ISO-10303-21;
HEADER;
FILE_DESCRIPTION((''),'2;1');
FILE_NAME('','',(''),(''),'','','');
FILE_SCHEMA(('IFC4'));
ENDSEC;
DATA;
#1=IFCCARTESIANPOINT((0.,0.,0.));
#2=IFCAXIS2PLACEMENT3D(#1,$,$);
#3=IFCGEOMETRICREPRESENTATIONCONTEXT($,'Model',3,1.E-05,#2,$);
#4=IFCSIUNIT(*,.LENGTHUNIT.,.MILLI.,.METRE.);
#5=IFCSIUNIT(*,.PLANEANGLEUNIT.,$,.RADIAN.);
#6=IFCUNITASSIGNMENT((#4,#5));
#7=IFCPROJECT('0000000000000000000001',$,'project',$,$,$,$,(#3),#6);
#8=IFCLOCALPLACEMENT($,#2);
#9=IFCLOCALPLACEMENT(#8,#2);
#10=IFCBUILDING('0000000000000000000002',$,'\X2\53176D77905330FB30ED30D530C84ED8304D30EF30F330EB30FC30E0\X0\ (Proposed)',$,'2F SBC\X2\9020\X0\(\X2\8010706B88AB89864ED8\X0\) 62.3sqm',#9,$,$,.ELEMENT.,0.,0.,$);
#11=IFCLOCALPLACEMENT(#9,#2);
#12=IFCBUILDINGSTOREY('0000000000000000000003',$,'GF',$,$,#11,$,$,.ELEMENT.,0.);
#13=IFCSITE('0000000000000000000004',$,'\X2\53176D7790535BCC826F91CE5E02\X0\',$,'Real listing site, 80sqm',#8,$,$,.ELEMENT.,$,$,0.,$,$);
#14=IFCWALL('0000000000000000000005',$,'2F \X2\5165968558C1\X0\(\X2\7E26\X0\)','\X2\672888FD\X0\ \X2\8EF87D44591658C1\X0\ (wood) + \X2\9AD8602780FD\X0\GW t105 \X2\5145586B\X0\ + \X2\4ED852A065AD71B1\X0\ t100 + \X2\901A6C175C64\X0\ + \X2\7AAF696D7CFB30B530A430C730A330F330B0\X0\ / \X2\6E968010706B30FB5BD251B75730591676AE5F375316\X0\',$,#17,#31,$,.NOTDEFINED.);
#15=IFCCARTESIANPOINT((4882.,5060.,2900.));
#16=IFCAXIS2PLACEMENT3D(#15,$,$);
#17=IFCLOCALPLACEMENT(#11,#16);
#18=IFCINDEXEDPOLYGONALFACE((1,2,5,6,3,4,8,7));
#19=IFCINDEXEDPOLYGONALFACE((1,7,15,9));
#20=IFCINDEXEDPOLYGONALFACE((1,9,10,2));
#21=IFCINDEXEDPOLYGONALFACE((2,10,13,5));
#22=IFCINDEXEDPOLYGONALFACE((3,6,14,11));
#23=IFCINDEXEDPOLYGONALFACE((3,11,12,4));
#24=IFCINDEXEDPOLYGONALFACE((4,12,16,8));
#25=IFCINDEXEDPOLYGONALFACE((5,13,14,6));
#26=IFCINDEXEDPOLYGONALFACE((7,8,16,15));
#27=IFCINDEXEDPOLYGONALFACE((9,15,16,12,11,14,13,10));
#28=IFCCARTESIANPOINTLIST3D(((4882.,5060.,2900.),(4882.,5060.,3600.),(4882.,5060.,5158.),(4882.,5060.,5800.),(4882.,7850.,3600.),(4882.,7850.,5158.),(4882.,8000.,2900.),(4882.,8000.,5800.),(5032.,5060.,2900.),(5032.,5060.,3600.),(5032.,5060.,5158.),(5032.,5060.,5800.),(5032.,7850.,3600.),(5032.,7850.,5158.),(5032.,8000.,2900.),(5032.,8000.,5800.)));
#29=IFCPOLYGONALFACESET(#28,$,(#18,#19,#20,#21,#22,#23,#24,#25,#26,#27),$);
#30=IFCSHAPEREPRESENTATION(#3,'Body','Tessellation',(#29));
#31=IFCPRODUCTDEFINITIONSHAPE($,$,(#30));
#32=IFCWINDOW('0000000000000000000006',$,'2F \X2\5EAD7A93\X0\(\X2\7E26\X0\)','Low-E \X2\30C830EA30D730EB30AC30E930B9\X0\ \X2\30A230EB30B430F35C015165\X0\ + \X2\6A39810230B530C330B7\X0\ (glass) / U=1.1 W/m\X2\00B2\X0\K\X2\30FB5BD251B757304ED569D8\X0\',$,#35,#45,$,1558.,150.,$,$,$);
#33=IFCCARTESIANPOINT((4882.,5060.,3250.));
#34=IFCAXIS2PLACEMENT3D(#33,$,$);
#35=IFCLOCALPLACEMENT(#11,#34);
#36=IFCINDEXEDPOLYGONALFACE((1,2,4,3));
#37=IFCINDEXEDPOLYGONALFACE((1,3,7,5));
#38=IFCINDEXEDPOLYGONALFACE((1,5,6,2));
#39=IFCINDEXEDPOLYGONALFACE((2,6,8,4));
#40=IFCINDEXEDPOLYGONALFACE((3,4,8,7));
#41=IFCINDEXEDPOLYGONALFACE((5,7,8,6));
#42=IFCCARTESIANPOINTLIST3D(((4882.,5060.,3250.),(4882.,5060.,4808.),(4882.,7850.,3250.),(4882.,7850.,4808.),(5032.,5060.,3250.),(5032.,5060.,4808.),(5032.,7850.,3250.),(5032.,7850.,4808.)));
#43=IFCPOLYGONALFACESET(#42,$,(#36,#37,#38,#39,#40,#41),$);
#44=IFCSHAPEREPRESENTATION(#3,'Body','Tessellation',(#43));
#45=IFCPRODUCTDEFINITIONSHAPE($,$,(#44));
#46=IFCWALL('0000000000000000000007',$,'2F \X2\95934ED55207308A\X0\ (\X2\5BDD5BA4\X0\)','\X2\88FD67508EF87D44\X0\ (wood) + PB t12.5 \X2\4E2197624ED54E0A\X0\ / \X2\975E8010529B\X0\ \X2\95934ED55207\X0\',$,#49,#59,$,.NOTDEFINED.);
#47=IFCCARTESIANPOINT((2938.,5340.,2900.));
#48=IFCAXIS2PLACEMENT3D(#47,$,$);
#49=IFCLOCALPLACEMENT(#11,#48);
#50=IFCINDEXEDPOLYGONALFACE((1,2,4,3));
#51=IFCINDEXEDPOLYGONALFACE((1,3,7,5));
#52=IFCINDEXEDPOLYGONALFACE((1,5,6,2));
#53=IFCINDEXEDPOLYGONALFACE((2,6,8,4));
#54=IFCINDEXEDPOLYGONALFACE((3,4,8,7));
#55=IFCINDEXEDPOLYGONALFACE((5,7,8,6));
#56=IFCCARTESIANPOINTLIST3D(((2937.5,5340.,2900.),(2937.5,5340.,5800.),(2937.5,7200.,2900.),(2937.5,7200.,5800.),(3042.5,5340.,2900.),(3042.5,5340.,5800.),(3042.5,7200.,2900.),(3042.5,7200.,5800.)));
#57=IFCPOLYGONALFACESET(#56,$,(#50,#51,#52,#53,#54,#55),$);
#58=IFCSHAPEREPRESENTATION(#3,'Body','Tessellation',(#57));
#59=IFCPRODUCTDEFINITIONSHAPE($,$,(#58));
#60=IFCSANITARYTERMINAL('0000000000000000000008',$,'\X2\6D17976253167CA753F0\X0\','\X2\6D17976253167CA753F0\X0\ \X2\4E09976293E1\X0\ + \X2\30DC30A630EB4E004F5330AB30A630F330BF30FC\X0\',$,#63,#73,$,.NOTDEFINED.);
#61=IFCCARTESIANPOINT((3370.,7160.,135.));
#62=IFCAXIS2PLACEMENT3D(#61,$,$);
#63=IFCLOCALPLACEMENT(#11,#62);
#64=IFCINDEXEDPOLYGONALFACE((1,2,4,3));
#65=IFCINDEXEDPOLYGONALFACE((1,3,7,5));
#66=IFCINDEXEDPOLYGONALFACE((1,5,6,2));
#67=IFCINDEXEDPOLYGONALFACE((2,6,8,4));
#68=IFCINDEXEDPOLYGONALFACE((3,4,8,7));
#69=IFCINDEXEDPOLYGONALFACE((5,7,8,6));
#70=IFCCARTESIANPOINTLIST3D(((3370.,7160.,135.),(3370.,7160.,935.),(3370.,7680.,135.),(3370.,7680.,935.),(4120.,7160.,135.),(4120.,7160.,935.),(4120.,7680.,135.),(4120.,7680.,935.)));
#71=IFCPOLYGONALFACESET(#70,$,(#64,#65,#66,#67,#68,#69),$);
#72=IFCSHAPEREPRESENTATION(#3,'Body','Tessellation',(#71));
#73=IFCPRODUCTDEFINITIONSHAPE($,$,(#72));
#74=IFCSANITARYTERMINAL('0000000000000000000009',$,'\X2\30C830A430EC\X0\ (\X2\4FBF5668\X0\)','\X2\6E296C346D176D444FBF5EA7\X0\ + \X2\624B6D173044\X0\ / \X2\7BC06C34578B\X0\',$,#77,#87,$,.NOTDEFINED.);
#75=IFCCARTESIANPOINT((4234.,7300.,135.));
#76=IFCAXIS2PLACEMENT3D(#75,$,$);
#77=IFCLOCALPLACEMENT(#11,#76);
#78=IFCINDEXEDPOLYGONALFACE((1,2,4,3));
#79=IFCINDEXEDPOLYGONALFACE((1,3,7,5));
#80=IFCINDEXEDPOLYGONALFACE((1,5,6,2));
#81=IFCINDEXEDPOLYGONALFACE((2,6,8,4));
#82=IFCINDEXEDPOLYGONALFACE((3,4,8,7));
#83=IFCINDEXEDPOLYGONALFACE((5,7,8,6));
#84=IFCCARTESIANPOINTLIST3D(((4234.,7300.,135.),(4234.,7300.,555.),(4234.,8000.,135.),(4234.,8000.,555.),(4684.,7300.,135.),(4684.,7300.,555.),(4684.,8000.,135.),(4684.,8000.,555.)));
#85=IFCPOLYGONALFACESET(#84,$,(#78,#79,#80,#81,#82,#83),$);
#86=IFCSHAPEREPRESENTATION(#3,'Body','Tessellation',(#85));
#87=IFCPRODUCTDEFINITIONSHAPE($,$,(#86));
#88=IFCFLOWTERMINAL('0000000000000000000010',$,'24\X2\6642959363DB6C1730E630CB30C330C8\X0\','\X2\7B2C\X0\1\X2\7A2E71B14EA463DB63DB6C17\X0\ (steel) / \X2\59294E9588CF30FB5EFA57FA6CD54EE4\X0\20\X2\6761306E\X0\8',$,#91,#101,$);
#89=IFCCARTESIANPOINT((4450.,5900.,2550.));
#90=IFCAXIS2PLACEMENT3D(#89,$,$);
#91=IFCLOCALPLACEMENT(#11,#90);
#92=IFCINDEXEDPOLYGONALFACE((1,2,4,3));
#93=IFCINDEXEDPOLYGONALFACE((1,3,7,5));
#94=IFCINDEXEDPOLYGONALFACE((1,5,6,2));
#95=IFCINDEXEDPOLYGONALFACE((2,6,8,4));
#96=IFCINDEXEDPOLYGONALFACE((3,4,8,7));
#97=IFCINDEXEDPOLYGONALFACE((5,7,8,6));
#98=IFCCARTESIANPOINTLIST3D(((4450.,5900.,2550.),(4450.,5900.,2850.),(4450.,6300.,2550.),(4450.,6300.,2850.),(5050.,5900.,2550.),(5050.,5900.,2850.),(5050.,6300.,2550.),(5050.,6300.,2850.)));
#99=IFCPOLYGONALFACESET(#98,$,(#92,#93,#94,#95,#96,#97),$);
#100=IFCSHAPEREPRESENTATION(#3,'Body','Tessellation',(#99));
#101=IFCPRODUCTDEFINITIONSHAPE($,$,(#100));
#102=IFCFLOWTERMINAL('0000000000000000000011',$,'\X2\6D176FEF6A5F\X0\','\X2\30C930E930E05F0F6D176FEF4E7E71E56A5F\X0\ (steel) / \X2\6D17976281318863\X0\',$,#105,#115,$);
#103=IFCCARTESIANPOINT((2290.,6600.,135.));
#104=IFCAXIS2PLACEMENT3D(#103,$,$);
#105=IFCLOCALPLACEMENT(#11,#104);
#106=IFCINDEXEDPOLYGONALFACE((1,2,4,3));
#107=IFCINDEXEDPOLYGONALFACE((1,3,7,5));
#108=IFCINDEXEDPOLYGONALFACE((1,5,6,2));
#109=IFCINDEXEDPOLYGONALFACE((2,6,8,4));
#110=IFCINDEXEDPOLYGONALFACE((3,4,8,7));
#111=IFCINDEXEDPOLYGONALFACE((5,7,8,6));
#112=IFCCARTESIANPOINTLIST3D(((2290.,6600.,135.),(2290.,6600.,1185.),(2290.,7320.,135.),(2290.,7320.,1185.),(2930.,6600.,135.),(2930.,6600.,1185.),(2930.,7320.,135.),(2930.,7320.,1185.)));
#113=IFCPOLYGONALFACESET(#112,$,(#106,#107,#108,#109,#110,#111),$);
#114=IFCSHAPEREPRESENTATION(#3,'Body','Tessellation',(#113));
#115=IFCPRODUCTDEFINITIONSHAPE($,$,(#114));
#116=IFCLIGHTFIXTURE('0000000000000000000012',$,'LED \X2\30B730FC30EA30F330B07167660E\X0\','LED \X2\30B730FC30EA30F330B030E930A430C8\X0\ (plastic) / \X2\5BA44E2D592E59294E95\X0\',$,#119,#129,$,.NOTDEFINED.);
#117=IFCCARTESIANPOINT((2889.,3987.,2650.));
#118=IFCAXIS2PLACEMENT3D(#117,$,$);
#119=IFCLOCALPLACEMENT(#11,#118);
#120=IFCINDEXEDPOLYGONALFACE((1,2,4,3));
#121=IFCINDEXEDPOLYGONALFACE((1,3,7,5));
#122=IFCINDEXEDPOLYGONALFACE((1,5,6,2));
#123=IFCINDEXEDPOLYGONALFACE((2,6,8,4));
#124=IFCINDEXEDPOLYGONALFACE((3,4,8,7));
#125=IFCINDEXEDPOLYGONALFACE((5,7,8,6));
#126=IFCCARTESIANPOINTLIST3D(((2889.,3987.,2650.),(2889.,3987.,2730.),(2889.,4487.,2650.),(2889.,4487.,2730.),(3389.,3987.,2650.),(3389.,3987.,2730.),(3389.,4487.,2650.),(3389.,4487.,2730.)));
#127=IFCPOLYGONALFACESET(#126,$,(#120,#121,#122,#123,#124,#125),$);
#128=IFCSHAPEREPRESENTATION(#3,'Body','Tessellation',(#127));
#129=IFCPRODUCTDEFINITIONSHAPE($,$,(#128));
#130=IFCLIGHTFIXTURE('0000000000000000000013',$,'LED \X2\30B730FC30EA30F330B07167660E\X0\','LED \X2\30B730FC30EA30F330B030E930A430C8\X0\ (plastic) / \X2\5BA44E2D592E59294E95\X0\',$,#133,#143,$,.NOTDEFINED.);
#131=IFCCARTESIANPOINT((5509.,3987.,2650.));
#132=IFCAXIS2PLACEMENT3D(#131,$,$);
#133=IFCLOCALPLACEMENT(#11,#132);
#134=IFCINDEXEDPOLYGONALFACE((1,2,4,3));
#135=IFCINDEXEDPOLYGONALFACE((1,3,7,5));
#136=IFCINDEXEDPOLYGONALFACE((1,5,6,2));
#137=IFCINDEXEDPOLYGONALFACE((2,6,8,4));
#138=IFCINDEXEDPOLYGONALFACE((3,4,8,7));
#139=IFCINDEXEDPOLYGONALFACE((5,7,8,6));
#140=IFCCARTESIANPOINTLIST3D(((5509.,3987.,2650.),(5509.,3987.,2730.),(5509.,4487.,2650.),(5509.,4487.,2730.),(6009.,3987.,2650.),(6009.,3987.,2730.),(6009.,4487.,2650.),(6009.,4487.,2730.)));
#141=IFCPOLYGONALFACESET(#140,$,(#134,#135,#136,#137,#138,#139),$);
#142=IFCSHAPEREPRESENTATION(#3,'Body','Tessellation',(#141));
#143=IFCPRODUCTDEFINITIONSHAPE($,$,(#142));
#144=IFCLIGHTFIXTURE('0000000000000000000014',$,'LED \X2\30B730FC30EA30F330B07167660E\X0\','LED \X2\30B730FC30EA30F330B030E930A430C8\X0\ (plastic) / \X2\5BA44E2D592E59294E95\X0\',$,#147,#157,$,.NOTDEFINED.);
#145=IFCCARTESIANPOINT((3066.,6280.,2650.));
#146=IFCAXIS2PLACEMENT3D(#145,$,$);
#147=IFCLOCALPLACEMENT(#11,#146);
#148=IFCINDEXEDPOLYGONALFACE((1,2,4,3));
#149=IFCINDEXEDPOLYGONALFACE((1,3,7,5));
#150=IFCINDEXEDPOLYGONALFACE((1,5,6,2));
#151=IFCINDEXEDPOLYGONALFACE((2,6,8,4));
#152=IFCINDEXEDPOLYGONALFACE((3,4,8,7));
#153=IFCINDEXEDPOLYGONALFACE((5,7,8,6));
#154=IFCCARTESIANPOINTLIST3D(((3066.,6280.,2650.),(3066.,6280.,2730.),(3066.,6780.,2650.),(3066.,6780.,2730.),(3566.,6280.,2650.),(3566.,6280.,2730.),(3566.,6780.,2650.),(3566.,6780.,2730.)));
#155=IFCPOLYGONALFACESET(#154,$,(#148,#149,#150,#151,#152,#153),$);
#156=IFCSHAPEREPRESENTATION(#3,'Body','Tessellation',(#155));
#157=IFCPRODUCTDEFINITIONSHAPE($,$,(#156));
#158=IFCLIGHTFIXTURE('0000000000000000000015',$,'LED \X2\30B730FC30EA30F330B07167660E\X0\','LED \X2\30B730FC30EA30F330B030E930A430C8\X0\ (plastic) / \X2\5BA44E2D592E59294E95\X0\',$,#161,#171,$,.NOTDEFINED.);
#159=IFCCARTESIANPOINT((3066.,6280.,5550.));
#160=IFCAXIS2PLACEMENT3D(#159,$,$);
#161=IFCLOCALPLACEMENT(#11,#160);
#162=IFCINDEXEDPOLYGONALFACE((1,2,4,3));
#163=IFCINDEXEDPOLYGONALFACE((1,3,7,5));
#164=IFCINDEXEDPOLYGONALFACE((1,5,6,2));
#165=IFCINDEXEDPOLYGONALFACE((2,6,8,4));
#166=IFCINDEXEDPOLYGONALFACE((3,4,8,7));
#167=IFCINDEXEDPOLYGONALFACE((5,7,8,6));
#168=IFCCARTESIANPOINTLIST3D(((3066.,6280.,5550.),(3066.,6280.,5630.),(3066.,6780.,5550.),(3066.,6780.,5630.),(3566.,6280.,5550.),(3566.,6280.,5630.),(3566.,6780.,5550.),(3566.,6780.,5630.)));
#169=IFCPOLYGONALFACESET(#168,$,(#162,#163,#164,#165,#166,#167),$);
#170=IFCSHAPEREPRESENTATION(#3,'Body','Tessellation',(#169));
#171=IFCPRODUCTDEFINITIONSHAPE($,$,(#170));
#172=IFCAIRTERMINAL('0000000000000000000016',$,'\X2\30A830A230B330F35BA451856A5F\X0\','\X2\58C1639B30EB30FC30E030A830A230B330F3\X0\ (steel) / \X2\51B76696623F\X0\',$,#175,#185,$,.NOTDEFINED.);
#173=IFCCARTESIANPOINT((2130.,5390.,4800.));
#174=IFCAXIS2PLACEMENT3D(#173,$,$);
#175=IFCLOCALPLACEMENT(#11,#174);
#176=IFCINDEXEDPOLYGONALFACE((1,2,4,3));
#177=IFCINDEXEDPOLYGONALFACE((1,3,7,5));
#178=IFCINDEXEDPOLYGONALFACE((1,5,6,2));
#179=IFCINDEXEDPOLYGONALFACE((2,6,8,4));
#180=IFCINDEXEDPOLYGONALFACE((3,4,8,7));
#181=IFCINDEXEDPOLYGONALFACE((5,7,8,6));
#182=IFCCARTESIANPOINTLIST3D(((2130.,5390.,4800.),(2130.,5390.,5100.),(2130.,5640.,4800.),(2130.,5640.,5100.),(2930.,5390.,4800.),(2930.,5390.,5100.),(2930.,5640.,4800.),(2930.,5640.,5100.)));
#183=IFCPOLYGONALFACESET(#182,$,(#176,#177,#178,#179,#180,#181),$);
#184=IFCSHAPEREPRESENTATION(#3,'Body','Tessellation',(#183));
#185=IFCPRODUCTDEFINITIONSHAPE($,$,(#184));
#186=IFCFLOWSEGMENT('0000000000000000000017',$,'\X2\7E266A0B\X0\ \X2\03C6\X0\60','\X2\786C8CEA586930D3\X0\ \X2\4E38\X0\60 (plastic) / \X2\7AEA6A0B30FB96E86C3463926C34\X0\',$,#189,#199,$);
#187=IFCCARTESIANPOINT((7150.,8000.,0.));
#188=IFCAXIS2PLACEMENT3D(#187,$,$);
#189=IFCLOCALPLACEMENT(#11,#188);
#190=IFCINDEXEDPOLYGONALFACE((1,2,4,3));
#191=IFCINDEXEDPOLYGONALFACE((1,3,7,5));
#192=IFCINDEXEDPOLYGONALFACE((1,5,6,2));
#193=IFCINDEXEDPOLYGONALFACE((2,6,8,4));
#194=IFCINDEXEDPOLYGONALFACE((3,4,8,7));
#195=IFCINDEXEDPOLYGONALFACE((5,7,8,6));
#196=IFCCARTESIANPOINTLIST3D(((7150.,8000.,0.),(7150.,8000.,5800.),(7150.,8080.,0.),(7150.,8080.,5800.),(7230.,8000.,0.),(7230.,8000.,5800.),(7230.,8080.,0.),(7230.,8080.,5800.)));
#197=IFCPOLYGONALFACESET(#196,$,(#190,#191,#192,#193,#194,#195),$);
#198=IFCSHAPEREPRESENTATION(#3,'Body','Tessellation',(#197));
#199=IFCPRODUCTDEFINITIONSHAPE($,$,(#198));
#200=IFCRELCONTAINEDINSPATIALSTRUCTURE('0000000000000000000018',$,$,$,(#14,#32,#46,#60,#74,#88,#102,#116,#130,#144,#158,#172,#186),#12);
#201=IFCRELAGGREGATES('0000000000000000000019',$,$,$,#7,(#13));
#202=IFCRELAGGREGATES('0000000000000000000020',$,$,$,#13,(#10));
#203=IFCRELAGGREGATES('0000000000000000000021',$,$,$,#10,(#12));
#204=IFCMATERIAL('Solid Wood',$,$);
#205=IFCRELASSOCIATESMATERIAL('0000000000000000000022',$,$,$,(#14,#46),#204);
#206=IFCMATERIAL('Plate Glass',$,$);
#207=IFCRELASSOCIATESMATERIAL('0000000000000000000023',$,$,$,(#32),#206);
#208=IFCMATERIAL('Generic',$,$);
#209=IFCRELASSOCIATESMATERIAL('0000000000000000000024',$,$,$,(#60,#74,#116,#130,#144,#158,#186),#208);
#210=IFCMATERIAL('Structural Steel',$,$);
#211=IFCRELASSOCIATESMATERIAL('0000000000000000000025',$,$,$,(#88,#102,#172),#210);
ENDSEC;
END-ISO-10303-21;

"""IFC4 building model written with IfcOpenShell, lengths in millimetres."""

from ifc_helpers import new_model, si_unit, frame, frame_2d, origin, place, context, project, spatial, rectangle, extrude, material, element, fill, save


model = new_model("IFC4")

# Units and contexts
model_context = context("Model", 3, precision=1e-05, world=origin())
ifc_project = project(units=[si_unit("LENGTHUNIT", "METRE", prefix="MILLI"), si_unit("PLANEANGLEUNIT", "RADIAN")], contexts=[model_context])

# Site, building, storey
site_placement = place(None, origin())
site = spatial("IfcSite", under=ifc_project, at=site_placement, Name="北海道富良野市", ObjectType="Real listing site, 80sqm", CompositionType="ELEMENT", RefElevation=0.0)
building_placement = place(site_placement, origin())
building = spatial("IfcBuilding", under=site, at=building_placement, Name="北海道・ロフト付きワンルーム (Proposed)", ObjectType="2F SBC造(耐火被覆付) 62.3sqm", CompositionType="ELEMENT", ElevationOfRefHeight=0.0, ElevationOfTerrain=0.0)
storey_placement = place(building_placement, origin())
storey = spatial("IfcBuildingStorey", under=building, at=storey_placement, Name="GF", CompositionType="ELEMENT", Elevation=0.0)

# Shared definitions
ifc_material_1 = material(Name="Solid Wood")

# Shared definitions
ifc_material_2 = material(Name="Plate Glass")

# Wall, opening, window
wall_1_placement = place(storey_placement, frame((4882.0, 5060.0, 2900.0)))
wall_1 = element("IfcWall", 1, at=wall_1_placement, inside=storey, material=ifc_material_1, Name="2F 入隅壁(縦)", Description="木製 軸組外壁 (wood) + 高性能GW t105 充填 + 付加断熱 t100 + 通気層 + 窯業系サイディング / 準耐火・寒冷地外皮強化", PredefinedType="NOTDEFINED", context=model_context, shape_type="SweptSolid", body=[
    extrude(rectangle(XDim=150.0, YDim=2940.0, at=frame_2d((75.0, 1470.0))), frame((4882.0, 5060.0, 2900.0)), (0.0, 0.0, 1.0), 2900.0),
])
opening_1_placement = place(storey_placement, frame((4882.0, 5060.0, 3250.0)))
opening_1 = element("IfcOpeningElement", 2, at=opening_1_placement, cuts=wall_1, PredefinedType="NOTDEFINED", context=model_context, shape_type="SweptSolid", body=[
    extrude(rectangle(XDim=150.0, YDim=2790.0, at=frame_2d((75.0, 1395.0))), frame((4882.0, 5060.0, 3250.0)), (0.0, 0.0, 1.0), 1558.0),
])
window_1_placement = place(storey_placement, frame((4882.0, 5060.0, 3250.0)))
window_1 = element("IfcWindow", 3, at=window_1_placement, inside=storey, material=ifc_material_2, Name="2F 庭窓(縦)", Description="Low-E トリプルガラス アルゴン封入 + 樹脂サッシ (glass) / U=1.1 W/m²K・寒冷地仕様", OverallHeight=1558.0, OverallWidth=150.0, context=model_context, shape_type="SweptSolid", body=[
    extrude(rectangle(XDim=150.0, YDim=2790.0, at=frame_2d((75.0, 1395.0))), frame((4882.0, 5060.0, 3250.0)), (0.0, 0.0, 1.0), 1558.0),
])
fill(opening_1, window_1)

# Wall
wall_2_placement = place(storey_placement, frame((2938.0, 5340.0, 2900.0)))
element("IfcWall", 4, at=wall_2_placement, inside=storey, material=ifc_material_1, Name="2F 間仕切り (寝室)", Description="製材軸組 (wood) + PB t12.5 両面仕上 / 非耐力 間仕切", PredefinedType="NOTDEFINED", context=model_context, shape_type="SweptSolid", body=[
    extrude(rectangle(XDim=105.0, YDim=1860.0, at=frame_2d((52.0, 930.0))), frame((2938.0, 5340.0, 2900.0)), (0.0, 0.0, 1.0), 2900.0),
])

# Sanitary terminals
ifc_material_3 = material(Name="Generic")
sanitary_terminal_1_placement = place(storey_placement, frame((3370.0, 7160.0, 135.0)))
element("IfcSanitaryTerminal", 5, at=sanitary_terminal_1_placement, inside=storey, material=ifc_material_3, Name="洗面化粧台", Description="洗面化粧台 三面鏡 + ボウル一体カウンター", PredefinedType="NOTDEFINED", context=model_context, shape_type="SweptSolid", body=[
    extrude(rectangle(XDim=750.0, YDim=520.0, at=frame_2d((375.0, 260.0))), frame((3370.0, 7160.0, 135.0)), (0.0, 0.0, 1.0), 800.0),
])
sanitary_terminal_2_placement = place(storey_placement, frame((4234.0, 7300.0, 135.0)))
element("IfcSanitaryTerminal", 6, at=sanitary_terminal_2_placement, inside=storey, material=ifc_material_3, Name="トイレ (便器)", Description="温水洗浄便座 + 手洗い / 節水型", PredefinedType="NOTDEFINED", context=model_context, shape_type="SweptSolid", body=[
    extrude(rectangle(XDim=450.0, YDim=700.0, at=frame_2d((225.0, 350.0))), frame((4234.0, 7300.0, 135.0)), (0.0, 0.0, 1.0), 420.0),
])

# Flow terminals
ifc_material_4 = material(Name="Structural Steel")
flow_terminal_1_placement = place(storey_placement, frame((4450.0, 5900.0, 2550.0)))
element("IfcFlowTerminal", 7, at=flow_terminal_1_placement, inside=storey, material=ifc_material_4, Name="24時間換気ユニット", Description="第1種熱交換換気 (steel) / 天井裏・建基法令20条の8", context=model_context, shape_type="SweptSolid", body=[
    extrude(rectangle(XDim=600.0, YDim=400.0, at=frame_2d((300.0, 200.0))), frame((4450.0, 5900.0, 2550.0)), (0.0, 0.0, 1.0), 300.0),
])
flow_terminal_2_placement = place(storey_placement, frame((2290.0, 6600.0, 135.0)))
element("IfcFlowTerminal", 8, at=flow_terminal_2_placement, inside=storey, material=ifc_material_4, Name="洗濯機", Description="ドラム式洗濯乾燥機 (steel) / 洗面脱衣", context=model_context, shape_type="SweptSolid", body=[
    extrude(rectangle(XDim=640.0, YDim=720.0, at=frame_2d((320.0, 360.0))), frame((2290.0, 6600.0, 135.0)), (0.0, 0.0, 1.0), 1050.0),
])

# Light fixtures
light_fixture_1_placement = place(storey_placement, frame((2889.0, 3987.0, 2650.0)))
element("IfcLightFixture", 9, at=light_fixture_1_placement, inside=storey, material=ifc_material_3, Name="LED シーリング照明", Description="LED シーリングライト (plastic) / 室中央天井", PredefinedType="NOTDEFINED", context=model_context, shape_type="SweptSolid", body=[
    extrude(rectangle(XDim=500.0, YDim=500.0, at=frame_2d((250.0, 250.0))), frame((2889.0, 3987.0, 2650.0)), (0.0, 0.0, 1.0), 80.0),
])
light_fixture_2_placement = place(storey_placement, frame((5509.0, 3987.0, 2650.0)))
element("IfcLightFixture", 10, at=light_fixture_2_placement, inside=storey, material=ifc_material_3, Name="LED シーリング照明", Description="LED シーリングライト (plastic) / 室中央天井", PredefinedType="NOTDEFINED", context=model_context, shape_type="SweptSolid", body=[
    extrude(rectangle(XDim=500.0, YDim=500.0, at=frame_2d((250.0, 250.0))), frame((5509.0, 3987.0, 2650.0)), (0.0, 0.0, 1.0), 80.0),
])
light_fixture_3_placement = place(storey_placement, frame((3066.0, 6280.0, 2650.0)))
element("IfcLightFixture", 11, at=light_fixture_3_placement, inside=storey, material=ifc_material_3, Name="LED シーリング照明", Description="LED シーリングライト (plastic) / 室中央天井", PredefinedType="NOTDEFINED", context=model_context, shape_type="SweptSolid", body=[
    extrude(rectangle(XDim=500.0, YDim=500.0, at=frame_2d((250.0, 250.0))), frame((3066.0, 6280.0, 2650.0)), (0.0, 0.0, 1.0), 80.0),
])
light_fixture_4_placement = place(storey_placement, frame((3066.0, 6280.0, 5550.0)))
element("IfcLightFixture", 12, at=light_fixture_4_placement, inside=storey, material=ifc_material_3, Name="LED シーリング照明", Description="LED シーリングライト (plastic) / 室中央天井", PredefinedType="NOTDEFINED", context=model_context, shape_type="SweptSolid", body=[
    extrude(rectangle(XDim=500.0, YDim=500.0, at=frame_2d((250.0, 250.0))), frame((3066.0, 6280.0, 5550.0)), (0.0, 0.0, 1.0), 80.0),
])

# Air terminal
air_terminal_placement = place(storey_placement, frame((2130.0, 5390.0, 4800.0)))
element("IfcAirTerminal", 13, at=air_terminal_placement, inside=storey, material=ifc_material_4, Name="エアコン室内機", Description="壁掛ルームエアコン (steel) / 冷暖房", PredefinedType="NOTDEFINED", context=model_context, shape_type="SweptSolid", body=[
    extrude(rectangle(XDim=800.0, YDim=250.0, at=frame_2d((400.0, 125.0))), frame((2130.0, 5390.0, 4800.0)), (0.0, 0.0, 1.0), 300.0),
])

# Flow segment
flow_segment_placement = place(storey_placement, frame((7150.0, 8000.0, 0.0)))
element("IfcFlowSegment", 14, at=flow_segment_placement, inside=storey, material=ifc_material_3, Name="縦樋 φ60", Description="硬質塩ビ 丸60 (plastic) / 竪樋・雨水排水", context=model_context, shape_type="SweptSolid", body=[
    extrude(rectangle(XDim=80.0, YDim=80.0, at=frame_2d((40.0, 40.0))), frame((7150.0, 8000.0, 0.0)), (0.0, 0.0, 1.0), 5800.0),
])

save(model, "model.ifc")
